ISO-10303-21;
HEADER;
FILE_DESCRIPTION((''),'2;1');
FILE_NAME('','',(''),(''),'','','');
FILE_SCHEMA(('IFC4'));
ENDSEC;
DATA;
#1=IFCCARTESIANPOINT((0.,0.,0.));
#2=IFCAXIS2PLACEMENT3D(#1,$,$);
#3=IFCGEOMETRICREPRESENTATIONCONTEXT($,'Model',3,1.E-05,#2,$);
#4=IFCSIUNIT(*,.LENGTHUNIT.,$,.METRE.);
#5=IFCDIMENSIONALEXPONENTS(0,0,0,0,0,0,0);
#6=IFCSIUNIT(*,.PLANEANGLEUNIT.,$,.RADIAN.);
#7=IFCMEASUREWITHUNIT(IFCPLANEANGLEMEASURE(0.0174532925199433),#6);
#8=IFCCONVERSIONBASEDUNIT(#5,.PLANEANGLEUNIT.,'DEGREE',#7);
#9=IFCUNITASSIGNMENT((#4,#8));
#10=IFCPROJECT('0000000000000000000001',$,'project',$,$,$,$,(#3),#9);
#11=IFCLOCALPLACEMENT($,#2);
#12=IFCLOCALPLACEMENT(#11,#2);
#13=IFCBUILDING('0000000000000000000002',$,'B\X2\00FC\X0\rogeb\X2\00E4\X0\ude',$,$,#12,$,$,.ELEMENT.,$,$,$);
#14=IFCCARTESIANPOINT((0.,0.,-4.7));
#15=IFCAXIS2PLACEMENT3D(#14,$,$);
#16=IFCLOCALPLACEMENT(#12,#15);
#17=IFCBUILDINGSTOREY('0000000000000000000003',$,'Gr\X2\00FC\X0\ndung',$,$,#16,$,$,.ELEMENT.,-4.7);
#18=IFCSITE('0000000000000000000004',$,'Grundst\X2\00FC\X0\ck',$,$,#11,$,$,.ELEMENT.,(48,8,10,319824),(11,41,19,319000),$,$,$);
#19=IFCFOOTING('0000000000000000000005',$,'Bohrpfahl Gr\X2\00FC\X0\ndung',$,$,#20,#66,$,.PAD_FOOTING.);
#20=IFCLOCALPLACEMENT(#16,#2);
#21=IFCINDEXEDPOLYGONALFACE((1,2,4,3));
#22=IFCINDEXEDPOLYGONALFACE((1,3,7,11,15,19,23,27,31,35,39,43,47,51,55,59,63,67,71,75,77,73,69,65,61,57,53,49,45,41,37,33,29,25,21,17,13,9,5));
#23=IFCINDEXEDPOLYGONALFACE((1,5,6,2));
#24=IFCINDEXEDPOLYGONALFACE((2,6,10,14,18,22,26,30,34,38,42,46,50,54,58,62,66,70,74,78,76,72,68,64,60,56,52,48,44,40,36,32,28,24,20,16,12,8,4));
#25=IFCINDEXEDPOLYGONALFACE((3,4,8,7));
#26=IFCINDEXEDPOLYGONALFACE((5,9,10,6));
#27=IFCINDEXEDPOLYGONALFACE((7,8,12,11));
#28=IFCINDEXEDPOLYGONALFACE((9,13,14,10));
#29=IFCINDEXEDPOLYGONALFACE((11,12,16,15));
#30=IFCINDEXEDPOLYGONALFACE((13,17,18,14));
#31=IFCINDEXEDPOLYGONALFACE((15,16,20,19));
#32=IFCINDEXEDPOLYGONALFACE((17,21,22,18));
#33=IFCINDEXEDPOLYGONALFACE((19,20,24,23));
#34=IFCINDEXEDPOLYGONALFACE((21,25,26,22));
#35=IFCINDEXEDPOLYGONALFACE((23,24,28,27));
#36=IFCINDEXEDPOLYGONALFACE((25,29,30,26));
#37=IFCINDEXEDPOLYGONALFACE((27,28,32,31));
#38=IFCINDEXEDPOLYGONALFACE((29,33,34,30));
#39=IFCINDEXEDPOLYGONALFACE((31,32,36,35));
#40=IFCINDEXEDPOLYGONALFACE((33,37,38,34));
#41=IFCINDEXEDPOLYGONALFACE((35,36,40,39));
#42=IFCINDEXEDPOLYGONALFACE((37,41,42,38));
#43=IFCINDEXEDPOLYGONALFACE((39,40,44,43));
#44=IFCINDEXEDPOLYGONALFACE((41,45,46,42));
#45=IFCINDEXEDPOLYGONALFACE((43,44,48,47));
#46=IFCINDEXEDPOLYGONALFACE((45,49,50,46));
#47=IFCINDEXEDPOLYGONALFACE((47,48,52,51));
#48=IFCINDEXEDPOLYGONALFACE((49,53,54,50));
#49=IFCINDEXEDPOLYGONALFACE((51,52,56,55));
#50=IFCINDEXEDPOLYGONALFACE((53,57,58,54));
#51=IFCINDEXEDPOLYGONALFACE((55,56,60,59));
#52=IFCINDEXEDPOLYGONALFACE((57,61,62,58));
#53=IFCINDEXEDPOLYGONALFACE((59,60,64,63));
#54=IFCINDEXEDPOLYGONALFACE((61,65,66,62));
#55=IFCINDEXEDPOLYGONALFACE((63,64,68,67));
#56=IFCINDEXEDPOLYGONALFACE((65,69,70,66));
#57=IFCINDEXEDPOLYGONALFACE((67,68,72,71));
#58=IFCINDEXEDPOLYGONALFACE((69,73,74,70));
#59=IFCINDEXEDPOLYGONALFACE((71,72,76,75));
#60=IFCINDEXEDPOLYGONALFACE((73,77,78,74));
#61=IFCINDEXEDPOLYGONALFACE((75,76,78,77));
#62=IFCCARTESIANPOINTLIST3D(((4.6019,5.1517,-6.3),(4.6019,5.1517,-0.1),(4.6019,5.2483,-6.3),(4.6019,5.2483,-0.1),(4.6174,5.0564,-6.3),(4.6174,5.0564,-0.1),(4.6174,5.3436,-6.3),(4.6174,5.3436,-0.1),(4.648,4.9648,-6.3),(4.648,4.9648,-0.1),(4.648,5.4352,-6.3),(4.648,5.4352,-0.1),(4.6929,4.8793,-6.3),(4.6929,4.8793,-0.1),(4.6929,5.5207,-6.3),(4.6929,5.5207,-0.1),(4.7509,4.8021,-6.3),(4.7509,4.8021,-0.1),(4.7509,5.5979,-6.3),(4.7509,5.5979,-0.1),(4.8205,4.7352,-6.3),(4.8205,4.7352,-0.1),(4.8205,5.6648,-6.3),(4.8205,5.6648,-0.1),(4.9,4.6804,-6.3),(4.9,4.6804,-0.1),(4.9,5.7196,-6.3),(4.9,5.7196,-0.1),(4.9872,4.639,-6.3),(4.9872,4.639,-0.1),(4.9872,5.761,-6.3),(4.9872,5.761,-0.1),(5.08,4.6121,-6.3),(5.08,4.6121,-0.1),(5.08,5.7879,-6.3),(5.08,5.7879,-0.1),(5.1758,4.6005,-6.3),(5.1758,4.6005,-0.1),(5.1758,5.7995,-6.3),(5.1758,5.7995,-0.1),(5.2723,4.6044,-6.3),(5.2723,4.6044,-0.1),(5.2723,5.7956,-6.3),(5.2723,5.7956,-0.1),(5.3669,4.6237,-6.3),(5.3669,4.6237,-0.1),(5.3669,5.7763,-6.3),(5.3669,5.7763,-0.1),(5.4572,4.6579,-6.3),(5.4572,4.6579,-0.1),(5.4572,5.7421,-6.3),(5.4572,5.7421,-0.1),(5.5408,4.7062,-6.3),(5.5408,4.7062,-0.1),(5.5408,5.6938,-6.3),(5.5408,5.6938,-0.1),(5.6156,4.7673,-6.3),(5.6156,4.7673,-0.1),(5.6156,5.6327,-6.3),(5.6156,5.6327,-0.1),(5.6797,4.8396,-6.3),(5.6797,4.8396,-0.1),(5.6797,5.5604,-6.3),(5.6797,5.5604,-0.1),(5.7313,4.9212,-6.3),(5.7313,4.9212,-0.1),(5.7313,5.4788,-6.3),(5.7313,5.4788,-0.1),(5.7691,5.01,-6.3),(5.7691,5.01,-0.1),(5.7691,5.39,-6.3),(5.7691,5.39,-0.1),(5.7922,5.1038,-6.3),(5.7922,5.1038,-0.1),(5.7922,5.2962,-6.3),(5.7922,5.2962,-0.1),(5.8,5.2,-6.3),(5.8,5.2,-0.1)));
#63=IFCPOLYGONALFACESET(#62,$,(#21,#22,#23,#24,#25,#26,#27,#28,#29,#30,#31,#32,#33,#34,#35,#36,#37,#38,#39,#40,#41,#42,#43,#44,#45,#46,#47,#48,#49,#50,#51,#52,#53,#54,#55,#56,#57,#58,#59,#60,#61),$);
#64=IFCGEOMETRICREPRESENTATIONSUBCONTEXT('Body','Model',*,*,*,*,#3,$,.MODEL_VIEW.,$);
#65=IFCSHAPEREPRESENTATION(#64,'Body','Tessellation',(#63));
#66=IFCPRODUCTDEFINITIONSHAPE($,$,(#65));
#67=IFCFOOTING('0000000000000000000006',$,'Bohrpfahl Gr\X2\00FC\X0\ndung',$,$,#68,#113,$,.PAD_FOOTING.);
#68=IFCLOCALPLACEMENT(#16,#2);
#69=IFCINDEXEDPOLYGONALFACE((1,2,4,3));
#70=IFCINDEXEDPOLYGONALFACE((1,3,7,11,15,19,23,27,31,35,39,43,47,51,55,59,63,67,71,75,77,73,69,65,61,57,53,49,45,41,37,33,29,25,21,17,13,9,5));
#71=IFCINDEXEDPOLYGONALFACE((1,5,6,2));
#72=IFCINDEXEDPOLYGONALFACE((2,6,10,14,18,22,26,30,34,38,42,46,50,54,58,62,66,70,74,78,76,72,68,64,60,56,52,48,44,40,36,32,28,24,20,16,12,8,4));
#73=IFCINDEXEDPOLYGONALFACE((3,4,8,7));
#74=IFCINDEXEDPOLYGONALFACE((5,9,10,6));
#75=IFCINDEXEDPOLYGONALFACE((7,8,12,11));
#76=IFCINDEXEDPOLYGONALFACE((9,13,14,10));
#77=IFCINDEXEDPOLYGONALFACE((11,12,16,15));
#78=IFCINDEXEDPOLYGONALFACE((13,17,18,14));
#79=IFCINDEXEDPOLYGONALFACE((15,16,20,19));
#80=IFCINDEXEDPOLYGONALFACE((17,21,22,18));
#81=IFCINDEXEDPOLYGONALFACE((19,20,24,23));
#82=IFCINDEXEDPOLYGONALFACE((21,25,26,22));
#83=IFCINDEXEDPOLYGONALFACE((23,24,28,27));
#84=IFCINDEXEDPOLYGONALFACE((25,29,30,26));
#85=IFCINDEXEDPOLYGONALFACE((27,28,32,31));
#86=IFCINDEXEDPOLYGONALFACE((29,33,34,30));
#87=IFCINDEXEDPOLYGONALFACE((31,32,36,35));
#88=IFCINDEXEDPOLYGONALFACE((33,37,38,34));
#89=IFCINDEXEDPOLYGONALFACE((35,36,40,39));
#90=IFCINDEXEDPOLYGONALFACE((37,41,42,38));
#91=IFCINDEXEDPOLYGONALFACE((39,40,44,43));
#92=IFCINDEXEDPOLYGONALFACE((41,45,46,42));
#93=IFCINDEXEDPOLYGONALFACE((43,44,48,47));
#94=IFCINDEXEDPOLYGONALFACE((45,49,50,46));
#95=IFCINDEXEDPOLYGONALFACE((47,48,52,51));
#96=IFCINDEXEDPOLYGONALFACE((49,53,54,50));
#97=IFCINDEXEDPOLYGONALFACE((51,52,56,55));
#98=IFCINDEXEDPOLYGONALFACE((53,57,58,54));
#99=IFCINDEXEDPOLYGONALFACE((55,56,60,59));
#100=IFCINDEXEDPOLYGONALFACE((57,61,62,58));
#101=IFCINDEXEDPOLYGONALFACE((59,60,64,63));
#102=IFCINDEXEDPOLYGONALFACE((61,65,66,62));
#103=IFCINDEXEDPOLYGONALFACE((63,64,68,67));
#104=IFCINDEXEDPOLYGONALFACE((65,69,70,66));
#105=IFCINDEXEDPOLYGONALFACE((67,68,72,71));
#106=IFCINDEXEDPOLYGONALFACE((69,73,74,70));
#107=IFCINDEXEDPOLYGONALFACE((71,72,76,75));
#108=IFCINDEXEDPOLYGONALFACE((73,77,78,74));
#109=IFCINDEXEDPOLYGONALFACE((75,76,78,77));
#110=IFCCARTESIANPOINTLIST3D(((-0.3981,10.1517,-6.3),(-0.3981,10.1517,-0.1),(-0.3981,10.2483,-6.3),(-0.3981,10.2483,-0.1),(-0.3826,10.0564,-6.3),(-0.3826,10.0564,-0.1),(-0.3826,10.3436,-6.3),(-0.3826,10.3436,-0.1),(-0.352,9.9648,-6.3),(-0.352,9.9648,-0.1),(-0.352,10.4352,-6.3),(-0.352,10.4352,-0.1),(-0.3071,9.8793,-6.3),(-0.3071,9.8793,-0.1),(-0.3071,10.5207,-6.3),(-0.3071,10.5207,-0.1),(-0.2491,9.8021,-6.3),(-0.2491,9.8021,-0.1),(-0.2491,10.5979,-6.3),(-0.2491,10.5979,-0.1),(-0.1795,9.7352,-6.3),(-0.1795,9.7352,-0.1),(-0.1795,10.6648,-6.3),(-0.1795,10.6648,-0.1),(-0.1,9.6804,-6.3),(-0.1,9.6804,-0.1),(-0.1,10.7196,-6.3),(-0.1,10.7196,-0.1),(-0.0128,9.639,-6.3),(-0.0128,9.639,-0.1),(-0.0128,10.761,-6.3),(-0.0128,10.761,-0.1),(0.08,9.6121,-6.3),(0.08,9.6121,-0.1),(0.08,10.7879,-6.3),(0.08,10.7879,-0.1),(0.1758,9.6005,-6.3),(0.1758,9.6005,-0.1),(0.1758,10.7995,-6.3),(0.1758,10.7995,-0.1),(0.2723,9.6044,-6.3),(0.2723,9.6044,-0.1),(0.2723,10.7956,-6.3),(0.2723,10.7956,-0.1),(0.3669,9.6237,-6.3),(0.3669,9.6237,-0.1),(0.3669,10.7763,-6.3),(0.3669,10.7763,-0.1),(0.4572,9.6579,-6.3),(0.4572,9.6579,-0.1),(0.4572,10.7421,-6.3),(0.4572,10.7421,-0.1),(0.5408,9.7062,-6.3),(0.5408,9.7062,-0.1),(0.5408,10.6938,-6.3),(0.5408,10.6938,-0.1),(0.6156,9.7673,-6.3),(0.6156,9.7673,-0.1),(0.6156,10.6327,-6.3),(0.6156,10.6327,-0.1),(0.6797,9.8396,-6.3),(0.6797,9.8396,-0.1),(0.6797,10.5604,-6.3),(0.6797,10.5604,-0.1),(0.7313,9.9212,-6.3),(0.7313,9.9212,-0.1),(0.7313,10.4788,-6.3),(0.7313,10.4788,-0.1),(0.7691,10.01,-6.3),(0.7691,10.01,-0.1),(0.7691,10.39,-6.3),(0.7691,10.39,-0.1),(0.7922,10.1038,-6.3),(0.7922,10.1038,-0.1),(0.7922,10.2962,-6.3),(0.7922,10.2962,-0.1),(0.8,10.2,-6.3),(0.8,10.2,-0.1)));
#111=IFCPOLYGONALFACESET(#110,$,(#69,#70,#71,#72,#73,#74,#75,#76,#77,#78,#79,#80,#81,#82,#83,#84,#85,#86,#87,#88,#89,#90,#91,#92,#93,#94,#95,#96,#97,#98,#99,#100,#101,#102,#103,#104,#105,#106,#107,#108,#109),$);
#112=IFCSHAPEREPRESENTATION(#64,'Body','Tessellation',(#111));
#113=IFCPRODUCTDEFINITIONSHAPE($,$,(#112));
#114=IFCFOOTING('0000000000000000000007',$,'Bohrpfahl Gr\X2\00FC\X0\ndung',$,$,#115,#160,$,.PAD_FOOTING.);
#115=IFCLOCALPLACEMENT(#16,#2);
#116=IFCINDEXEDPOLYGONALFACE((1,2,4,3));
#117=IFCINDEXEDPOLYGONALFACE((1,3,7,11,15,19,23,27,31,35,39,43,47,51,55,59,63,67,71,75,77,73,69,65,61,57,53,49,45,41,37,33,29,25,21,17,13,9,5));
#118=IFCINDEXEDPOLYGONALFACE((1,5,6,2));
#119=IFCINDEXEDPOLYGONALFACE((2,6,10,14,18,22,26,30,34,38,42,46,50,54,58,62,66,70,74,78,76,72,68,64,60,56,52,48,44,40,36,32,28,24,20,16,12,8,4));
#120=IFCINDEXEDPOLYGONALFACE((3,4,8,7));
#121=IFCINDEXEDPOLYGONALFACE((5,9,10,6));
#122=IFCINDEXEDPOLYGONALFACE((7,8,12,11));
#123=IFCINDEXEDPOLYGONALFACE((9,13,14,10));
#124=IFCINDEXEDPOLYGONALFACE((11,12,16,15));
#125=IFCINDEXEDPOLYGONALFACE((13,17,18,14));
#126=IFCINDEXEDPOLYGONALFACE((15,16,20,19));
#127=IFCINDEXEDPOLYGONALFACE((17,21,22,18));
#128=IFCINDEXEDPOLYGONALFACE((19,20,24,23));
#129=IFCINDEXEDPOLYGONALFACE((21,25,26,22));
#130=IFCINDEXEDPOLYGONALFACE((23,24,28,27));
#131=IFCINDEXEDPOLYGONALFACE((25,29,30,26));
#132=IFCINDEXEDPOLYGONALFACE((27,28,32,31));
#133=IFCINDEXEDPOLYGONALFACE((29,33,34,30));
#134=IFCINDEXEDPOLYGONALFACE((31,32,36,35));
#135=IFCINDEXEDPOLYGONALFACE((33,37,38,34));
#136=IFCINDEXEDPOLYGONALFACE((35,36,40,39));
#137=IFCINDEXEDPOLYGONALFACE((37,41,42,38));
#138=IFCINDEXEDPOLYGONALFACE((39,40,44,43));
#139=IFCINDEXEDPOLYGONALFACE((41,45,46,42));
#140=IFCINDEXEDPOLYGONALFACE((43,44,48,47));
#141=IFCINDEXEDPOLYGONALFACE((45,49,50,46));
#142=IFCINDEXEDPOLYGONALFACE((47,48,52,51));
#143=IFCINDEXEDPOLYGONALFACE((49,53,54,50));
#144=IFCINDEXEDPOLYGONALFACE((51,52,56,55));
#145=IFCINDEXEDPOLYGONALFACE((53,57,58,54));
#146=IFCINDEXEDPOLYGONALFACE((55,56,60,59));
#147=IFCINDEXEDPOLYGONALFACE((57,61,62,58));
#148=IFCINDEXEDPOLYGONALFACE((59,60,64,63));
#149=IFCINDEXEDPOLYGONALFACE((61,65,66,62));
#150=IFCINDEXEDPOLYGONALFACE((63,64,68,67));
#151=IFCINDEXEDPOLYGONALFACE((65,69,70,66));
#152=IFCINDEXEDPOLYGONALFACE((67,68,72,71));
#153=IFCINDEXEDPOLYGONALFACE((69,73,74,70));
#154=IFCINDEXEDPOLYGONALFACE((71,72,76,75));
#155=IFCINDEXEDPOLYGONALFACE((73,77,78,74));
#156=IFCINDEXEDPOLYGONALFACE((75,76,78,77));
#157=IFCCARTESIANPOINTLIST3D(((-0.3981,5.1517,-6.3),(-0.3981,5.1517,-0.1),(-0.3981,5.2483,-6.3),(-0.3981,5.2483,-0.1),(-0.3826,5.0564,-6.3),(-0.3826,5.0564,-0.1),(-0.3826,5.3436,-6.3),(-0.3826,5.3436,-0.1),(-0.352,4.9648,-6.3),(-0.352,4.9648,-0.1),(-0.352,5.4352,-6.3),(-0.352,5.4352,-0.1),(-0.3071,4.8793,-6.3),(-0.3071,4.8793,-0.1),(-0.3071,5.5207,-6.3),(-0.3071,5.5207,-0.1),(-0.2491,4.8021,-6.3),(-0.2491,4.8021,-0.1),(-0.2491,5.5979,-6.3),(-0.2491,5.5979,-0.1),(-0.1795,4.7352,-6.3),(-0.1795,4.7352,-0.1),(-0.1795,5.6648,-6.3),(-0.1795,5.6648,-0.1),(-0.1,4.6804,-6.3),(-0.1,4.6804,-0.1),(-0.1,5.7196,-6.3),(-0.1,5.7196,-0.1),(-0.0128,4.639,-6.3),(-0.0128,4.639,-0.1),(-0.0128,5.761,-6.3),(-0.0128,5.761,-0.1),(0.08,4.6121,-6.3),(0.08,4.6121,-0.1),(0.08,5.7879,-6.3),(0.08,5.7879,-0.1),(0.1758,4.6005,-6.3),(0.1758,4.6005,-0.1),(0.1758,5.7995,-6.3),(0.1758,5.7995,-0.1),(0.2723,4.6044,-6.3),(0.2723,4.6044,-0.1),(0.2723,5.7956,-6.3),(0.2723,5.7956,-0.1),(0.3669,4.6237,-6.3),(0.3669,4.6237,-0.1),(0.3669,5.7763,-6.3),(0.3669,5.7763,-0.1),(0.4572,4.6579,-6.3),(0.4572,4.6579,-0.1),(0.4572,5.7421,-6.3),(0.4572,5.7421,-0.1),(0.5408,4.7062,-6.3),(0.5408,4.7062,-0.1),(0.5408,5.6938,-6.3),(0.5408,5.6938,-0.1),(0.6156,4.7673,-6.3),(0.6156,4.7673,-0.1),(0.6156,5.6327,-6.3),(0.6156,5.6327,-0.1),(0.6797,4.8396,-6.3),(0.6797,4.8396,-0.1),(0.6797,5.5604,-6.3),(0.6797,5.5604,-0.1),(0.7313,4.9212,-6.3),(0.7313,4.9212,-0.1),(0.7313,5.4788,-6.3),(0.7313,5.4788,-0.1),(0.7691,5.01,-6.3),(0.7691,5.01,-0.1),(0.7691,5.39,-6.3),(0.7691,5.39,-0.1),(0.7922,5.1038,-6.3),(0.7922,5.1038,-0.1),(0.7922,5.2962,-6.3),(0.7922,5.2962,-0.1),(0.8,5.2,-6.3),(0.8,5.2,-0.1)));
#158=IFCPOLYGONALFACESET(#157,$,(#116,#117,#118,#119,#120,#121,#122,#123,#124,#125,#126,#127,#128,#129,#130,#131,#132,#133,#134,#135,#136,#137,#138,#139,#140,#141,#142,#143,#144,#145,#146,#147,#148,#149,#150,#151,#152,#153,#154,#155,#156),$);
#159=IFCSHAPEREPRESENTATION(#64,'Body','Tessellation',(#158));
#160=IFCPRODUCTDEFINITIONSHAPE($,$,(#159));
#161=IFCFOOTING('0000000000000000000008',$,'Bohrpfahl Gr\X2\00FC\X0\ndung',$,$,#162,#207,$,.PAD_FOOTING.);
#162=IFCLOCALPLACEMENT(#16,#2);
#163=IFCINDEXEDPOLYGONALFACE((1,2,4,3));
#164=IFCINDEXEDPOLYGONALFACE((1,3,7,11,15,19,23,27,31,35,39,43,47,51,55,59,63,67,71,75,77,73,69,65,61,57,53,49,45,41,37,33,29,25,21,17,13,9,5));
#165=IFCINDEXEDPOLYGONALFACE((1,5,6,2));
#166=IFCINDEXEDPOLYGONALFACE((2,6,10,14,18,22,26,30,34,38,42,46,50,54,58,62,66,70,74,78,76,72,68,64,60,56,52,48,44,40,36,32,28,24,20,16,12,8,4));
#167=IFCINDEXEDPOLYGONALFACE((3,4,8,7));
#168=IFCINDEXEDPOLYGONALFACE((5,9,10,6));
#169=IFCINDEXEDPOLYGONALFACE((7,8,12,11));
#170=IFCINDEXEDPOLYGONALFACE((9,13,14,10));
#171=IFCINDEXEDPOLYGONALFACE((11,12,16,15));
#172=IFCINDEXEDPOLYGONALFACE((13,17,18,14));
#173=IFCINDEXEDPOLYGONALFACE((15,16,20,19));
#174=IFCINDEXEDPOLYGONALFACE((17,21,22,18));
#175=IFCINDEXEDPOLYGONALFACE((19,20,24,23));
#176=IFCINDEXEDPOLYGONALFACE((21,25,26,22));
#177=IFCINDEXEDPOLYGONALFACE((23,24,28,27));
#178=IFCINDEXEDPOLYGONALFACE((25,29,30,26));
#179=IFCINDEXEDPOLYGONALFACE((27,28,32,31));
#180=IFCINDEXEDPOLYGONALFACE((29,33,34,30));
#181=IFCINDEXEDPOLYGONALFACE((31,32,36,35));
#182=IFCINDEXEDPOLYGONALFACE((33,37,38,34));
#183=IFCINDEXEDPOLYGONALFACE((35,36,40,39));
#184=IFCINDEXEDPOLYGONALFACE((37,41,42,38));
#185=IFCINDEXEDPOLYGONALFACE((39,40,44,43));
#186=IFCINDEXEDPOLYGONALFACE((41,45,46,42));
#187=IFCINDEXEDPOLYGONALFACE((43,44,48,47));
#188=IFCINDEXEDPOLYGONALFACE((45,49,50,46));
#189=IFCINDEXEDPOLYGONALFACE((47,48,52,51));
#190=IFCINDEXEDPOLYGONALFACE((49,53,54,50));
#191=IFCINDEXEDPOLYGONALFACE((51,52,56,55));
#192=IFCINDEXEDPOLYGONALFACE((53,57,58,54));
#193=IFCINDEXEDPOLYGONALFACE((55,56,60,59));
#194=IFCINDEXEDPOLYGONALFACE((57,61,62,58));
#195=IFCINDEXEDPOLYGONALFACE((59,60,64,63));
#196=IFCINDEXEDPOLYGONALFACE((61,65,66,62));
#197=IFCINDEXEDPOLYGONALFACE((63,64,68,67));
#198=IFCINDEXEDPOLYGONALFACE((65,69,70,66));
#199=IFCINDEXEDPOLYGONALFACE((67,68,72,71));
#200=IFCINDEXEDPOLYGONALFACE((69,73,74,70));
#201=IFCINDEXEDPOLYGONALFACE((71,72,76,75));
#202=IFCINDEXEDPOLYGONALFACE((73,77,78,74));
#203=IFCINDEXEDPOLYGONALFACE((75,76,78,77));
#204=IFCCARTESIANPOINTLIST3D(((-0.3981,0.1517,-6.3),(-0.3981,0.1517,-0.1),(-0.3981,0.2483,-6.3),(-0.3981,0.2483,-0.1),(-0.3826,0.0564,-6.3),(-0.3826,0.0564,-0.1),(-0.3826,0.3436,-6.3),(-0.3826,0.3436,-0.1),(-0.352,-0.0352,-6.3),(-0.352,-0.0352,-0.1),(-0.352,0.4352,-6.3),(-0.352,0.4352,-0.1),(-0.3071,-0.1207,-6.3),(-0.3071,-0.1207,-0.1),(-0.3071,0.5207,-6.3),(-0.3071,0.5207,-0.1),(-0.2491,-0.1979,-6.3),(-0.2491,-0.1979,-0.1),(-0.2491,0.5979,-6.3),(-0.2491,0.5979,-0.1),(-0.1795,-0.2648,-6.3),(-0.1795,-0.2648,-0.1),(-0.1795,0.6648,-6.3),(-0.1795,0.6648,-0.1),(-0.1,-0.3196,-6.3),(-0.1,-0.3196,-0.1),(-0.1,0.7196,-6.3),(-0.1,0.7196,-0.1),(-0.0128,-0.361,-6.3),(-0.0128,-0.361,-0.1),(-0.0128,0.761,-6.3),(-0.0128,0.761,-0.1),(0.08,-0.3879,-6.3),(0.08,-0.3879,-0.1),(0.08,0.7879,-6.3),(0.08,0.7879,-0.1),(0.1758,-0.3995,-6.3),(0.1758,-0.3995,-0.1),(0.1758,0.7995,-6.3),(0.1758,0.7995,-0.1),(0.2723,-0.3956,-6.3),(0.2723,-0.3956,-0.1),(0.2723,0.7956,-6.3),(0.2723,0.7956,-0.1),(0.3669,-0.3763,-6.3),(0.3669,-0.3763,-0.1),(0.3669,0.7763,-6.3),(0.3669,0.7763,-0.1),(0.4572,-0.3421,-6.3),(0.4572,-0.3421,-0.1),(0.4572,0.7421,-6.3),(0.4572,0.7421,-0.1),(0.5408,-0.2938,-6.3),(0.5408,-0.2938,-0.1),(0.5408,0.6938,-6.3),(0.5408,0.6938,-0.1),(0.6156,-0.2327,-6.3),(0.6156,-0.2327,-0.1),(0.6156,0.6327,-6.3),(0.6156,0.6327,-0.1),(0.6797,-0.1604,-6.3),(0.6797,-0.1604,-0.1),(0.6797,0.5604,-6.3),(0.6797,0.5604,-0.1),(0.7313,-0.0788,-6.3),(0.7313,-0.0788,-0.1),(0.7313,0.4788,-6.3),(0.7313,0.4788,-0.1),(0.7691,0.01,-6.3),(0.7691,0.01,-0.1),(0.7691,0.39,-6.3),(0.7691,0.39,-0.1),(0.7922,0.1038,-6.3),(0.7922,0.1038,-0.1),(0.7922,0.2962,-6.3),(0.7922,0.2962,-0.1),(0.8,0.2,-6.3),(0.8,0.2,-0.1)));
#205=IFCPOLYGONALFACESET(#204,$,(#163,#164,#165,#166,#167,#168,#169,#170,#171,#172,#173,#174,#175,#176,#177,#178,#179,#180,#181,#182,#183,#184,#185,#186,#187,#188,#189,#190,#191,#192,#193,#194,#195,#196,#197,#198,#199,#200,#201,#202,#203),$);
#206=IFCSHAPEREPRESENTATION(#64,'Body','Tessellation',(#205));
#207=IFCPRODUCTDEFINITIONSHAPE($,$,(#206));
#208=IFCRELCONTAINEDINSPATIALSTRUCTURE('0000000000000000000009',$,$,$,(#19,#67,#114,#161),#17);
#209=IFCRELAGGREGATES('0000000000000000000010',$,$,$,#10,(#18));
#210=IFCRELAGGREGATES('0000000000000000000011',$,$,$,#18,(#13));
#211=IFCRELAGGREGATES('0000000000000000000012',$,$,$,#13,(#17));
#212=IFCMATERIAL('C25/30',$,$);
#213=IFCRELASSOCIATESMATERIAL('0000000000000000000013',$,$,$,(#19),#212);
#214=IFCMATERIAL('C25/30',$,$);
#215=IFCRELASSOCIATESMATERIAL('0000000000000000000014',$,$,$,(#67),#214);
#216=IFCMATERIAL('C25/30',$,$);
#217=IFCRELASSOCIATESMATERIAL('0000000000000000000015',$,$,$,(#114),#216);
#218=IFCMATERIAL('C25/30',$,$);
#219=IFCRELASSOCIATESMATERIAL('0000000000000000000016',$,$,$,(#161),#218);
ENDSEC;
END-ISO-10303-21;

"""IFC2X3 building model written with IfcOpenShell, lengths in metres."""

from ifc_helpers import new_model, entity, si_unit, converted_unit, frame, frame_2d, origin, place, context, subcontext, project, spatial, circle, extrude, material, element, save


model = new_model("IFC2X3")

# Units and contexts
model_context = context("Model", 3, precision=1e-05, world=origin())
body_context = subcontext(model_context, "Body", "Model", "MODEL_VIEW")
ifc_project = project(units=[si_unit("LENGTHUNIT", "METRE"), converted_unit("PLANEANGLEUNIT", "DEGREE", entity("IfcPlaneAngleMeasure", 0.0174532925199433), si_unit("PLANEANGLEUNIT", "RADIAN"), dimensions=[0, 0, 0, 0, 0, 0, 0])], contexts=[model_context])

# Site, building, storey
site_placement = place(None, origin())
site = spatial("IfcSite", under=ifc_project, at=site_placement, Name="Grundstück", CompositionType="ELEMENT", RefLatitude=(48, 8, 10, 319824), RefLongitude=(11, 41, 19, 319000))
building_placement = place(site_placement, origin())
building = spatial("IfcBuilding", under=site, at=building_placement, Name="Bürogebäude", CompositionType="ELEMENT")
storey_placement = place(building_placement, frame((0.0, 0.0, -4.7)))
storey = spatial("IfcBuildingStorey", under=building, at=storey_placement, Name="Gründung", CompositionType="ELEMENT", Elevation=-4.7)

# Footings
ifc_material_1 = material(Name="C25/30")
footing_1_placement = place(storey_placement, frame((4.6025, 4.6025, -6.3)))
element("IfcFooting", 1, at=footing_1_placement, inside=storey, material=ifc_material_1, Name="Bohrpfahl Gründung", PredefinedType="PAD_FOOTING", context=body_context, shape_type="SweptSolid", body=[
    extrude(circle(Radius=0.6, at=frame_2d((0.6, 0.6), x_axis=(1.0, 0.0))), frame((-0.0025, -0.0025, 0.0), z_axis=(0.0, 0.0, 1.0), x_axis=(1.0, 0.0, 0.0)), (0.0, 0.0, 1.0), 6.2),
])
ifc_material_2 = material(Name="C25/30")
footing_2_placement = place(storey_placement, frame((-0.3975, 9.6025, -6.3)))
element("IfcFooting", 2, at=footing_2_placement, inside=storey, material=ifc_material_2, Name="Bohrpfahl Gründung", PredefinedType="PAD_FOOTING", context=body_context, shape_type="SweptSolid", body=[
    extrude(circle(Radius=0.6, at=frame_2d((0.6, 0.6), x_axis=(1.0, 0.0))), frame((-0.0025, -0.0025, 0.0), z_axis=(0.0, 0.0, 1.0), x_axis=(1.0, 0.0, 0.0)), (0.0, 0.0, 1.0), 6.2),
])
ifc_material_3 = material(Name="C25/30")
footing_3_placement = place(storey_placement, frame((-0.3975, 4.6025, -6.3)))
element("IfcFooting", 3, at=footing_3_placement, inside=storey, material=ifc_material_3, Name="Bohrpfahl Gründung", PredefinedType="PAD_FOOTING", context=body_context, shape_type="SweptSolid", body=[
    extrude(circle(Radius=0.6, at=frame_2d((0.6, 0.6), x_axis=(1.0, 0.0))), frame((-0.0025, -0.0025, 0.0), z_axis=(0.0, 0.0, 1.0), x_axis=(1.0, 0.0, 0.0)), (0.0, 0.0, 1.0), 6.2),
])
ifc_material_4 = material(Name="C25/30")
footing_4_placement = place(storey_placement, frame((-0.3975, -0.3975, -6.3)))
element("IfcFooting", 4, at=footing_4_placement, inside=storey, material=ifc_material_4, Name="Bohrpfahl Gründung", PredefinedType="PAD_FOOTING", context=body_context, shape_type="SweptSolid", body=[
    extrude(circle(Radius=0.6, at=frame_2d((0.6, 0.6), x_axis=(1.0, 0.0))), frame((-0.0025, -0.0025, 0.0), z_axis=(0.0, 0.0, 1.0), x_axis=(1.0, 0.0, 0.0)), (0.0, 0.0, 1.0), 6.2),
])

save(model, "model.ifc")
